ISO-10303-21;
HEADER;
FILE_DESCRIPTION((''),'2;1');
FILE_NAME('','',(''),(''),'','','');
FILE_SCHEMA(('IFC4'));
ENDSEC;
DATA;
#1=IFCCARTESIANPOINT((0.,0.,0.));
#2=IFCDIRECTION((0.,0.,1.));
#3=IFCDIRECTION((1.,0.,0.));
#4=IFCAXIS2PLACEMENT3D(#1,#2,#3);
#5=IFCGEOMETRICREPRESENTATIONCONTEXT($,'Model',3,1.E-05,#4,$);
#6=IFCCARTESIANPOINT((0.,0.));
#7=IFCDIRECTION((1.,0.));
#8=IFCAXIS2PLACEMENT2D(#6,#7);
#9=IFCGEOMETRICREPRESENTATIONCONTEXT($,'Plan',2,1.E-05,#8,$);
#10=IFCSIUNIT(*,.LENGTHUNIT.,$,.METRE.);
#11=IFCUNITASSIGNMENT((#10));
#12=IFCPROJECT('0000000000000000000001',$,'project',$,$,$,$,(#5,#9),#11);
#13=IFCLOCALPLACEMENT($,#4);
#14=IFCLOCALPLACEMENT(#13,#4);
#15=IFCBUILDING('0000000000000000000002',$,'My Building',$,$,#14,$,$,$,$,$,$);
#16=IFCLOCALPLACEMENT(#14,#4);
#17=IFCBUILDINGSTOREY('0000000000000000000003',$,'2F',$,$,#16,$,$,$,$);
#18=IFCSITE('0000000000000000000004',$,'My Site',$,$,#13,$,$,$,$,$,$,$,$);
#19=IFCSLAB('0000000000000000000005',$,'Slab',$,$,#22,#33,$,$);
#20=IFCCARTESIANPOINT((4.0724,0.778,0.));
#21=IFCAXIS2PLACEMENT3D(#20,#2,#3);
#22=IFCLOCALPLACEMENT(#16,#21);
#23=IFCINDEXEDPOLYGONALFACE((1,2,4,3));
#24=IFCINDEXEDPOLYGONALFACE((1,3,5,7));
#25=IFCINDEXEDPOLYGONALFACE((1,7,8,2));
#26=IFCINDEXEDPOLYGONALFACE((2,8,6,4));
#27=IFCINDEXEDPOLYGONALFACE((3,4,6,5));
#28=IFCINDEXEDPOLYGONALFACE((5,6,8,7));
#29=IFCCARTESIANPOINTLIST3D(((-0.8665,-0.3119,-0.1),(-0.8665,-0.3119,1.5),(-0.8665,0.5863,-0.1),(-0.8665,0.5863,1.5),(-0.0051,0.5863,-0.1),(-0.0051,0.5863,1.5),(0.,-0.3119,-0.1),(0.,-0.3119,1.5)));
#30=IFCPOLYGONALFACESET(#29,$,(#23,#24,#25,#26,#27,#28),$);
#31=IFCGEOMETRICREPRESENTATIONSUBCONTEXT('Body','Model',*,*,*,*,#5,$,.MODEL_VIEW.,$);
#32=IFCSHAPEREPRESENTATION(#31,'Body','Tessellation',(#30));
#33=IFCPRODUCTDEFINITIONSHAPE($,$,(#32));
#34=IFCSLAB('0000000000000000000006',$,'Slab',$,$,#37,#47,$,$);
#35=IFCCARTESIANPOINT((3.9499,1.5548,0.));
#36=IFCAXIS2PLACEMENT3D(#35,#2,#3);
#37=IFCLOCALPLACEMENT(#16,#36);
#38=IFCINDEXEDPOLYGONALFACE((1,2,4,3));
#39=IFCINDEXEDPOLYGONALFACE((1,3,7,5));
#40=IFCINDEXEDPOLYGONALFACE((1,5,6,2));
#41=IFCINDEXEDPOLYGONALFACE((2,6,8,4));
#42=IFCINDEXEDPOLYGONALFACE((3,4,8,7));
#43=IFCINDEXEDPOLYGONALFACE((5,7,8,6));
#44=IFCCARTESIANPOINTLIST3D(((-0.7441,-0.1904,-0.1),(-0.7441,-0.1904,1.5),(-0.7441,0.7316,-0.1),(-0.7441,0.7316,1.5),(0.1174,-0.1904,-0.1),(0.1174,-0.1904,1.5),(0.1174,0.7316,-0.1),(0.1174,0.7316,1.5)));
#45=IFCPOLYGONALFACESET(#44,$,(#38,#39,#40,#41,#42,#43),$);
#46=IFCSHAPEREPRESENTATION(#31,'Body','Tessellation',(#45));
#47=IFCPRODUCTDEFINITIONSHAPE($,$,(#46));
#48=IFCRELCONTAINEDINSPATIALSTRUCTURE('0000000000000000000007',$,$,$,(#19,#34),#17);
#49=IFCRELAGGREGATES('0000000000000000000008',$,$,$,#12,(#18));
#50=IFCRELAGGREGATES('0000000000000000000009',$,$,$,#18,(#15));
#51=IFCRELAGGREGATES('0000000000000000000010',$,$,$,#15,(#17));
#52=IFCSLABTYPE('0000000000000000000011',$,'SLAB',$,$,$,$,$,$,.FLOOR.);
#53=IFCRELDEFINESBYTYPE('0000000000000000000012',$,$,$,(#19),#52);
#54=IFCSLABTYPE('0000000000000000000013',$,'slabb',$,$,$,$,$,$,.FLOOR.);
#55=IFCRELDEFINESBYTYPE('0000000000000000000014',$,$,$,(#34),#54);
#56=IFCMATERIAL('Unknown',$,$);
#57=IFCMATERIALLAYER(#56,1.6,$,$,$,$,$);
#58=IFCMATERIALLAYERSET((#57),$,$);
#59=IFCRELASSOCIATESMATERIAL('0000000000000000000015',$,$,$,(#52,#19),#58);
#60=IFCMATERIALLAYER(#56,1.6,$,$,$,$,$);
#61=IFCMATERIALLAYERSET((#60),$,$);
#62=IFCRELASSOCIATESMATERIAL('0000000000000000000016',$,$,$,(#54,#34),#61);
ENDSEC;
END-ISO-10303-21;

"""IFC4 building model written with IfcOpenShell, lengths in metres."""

from ifc_helpers import new_model, si_unit, frame, origin_with_axes, origin_2d_with_axis, place, context, subcontext, project, spatial, indexed_curve, outline, extrude, material, layer, layer_set, layer_usage, type_object, element, save


model = new_model("IFC4")

# Units and contexts
model_context = context("Model", 3, precision=1e-05, world=origin_with_axes())
plan_context = context("Plan", 2, precision=1e-05, world=origin_2d_with_axis())
body_context = subcontext(model_context, "Body", "Model", "MODEL_VIEW")
ifc_project = project(units=[si_unit("LENGTHUNIT", "METRE")], contexts=[model_context, plan_context])

# Site, building, storey
site_placement = place(None, origin_with_axes())
site = spatial("IfcSite", under=ifc_project, at=site_placement, Name="My Site")
building_placement = place(site_placement, origin_with_axes())
building = spatial("IfcBuilding", under=site, at=building_placement, Name="My Building")
storey_placement = place(building_placement, origin_with_axes())
storey = spatial("IfcBuildingStorey", under=building, at=storey_placement, Name="2F")

# Slabs
ifc_material = material(Name="Unknown")
ifc_layer_1 = layer(ifc_material, 1.6)
ifc_layer_set_1 = layer_set([ifc_layer_1])
ifc_layer_usage_1 = layer_usage(ifc_layer_set_1, "AXIS3", "POSITIVE", -0.1)
slab_type_1 = type_object("IfcSlabType", Name="SLAB", PredefinedType="FLOOR", material=ifc_layer_set_1)
slab_1_placement = place(storey_placement, frame((4.0724, 0.778, 0.0), z_axis=(0.0, 0.0, 1.0), x_axis=(1.0, 0.0, 0.0)))
element("IfcSlab", 1, at=slab_1_placement, inside=storey, type_object=slab_type_1, material=ifc_layer_usage_1, Name="Slab", context=body_context, shape_type="SweptSolid", body=[
    extrude(outline(indexed_curve([(-0.8665, -0.3119), (-0.8665, 0.5863), (-0.0051, 0.5863), (0.0, -0.3119), (-0.8665, -0.3119)])), frame((0.0, 0.0, -0.1), z_axis=(0.0, 0.0, 1.0), x_axis=(1.0, 0.0, 0.0)), (0.0, 0.0, 1.0), 1.6),
])
ifc_layer_2 = layer(ifc_material, 1.6)
ifc_layer_set_2 = layer_set([ifc_layer_2])
ifc_layer_usage_2 = layer_usage(ifc_layer_set_2, "AXIS3", "POSITIVE", -0.1)
slab_type_2 = type_object("IfcSlabType", Name="slabb", PredefinedType="FLOOR", material=ifc_layer_set_2)
slab_2_placement = place(storey_placement, frame((3.9499, 1.5548, 0.0), z_axis=(0.0, 0.0, 1.0), x_axis=(1.0, 0.0, 0.0)))
element("IfcSlab", 2, at=slab_2_placement, inside=storey, type_object=slab_type_2, material=ifc_layer_usage_2, Name="Slab", context=body_context, shape_type="SweptSolid", body=[
    extrude(outline(indexed_curve([(0.1174, 0.7316), (-0.7441, 0.7316), (-0.7441, -0.1904), (0.1174, -0.1904), (0.1174, 0.7316)])), frame((0.0, 0.0, -0.1), z_axis=(0.0, 0.0, 1.0), x_axis=(1.0, 0.0, 0.0)), (0.0, 0.0, 1.0), 1.6),
])

save(model, "model.ifc")
